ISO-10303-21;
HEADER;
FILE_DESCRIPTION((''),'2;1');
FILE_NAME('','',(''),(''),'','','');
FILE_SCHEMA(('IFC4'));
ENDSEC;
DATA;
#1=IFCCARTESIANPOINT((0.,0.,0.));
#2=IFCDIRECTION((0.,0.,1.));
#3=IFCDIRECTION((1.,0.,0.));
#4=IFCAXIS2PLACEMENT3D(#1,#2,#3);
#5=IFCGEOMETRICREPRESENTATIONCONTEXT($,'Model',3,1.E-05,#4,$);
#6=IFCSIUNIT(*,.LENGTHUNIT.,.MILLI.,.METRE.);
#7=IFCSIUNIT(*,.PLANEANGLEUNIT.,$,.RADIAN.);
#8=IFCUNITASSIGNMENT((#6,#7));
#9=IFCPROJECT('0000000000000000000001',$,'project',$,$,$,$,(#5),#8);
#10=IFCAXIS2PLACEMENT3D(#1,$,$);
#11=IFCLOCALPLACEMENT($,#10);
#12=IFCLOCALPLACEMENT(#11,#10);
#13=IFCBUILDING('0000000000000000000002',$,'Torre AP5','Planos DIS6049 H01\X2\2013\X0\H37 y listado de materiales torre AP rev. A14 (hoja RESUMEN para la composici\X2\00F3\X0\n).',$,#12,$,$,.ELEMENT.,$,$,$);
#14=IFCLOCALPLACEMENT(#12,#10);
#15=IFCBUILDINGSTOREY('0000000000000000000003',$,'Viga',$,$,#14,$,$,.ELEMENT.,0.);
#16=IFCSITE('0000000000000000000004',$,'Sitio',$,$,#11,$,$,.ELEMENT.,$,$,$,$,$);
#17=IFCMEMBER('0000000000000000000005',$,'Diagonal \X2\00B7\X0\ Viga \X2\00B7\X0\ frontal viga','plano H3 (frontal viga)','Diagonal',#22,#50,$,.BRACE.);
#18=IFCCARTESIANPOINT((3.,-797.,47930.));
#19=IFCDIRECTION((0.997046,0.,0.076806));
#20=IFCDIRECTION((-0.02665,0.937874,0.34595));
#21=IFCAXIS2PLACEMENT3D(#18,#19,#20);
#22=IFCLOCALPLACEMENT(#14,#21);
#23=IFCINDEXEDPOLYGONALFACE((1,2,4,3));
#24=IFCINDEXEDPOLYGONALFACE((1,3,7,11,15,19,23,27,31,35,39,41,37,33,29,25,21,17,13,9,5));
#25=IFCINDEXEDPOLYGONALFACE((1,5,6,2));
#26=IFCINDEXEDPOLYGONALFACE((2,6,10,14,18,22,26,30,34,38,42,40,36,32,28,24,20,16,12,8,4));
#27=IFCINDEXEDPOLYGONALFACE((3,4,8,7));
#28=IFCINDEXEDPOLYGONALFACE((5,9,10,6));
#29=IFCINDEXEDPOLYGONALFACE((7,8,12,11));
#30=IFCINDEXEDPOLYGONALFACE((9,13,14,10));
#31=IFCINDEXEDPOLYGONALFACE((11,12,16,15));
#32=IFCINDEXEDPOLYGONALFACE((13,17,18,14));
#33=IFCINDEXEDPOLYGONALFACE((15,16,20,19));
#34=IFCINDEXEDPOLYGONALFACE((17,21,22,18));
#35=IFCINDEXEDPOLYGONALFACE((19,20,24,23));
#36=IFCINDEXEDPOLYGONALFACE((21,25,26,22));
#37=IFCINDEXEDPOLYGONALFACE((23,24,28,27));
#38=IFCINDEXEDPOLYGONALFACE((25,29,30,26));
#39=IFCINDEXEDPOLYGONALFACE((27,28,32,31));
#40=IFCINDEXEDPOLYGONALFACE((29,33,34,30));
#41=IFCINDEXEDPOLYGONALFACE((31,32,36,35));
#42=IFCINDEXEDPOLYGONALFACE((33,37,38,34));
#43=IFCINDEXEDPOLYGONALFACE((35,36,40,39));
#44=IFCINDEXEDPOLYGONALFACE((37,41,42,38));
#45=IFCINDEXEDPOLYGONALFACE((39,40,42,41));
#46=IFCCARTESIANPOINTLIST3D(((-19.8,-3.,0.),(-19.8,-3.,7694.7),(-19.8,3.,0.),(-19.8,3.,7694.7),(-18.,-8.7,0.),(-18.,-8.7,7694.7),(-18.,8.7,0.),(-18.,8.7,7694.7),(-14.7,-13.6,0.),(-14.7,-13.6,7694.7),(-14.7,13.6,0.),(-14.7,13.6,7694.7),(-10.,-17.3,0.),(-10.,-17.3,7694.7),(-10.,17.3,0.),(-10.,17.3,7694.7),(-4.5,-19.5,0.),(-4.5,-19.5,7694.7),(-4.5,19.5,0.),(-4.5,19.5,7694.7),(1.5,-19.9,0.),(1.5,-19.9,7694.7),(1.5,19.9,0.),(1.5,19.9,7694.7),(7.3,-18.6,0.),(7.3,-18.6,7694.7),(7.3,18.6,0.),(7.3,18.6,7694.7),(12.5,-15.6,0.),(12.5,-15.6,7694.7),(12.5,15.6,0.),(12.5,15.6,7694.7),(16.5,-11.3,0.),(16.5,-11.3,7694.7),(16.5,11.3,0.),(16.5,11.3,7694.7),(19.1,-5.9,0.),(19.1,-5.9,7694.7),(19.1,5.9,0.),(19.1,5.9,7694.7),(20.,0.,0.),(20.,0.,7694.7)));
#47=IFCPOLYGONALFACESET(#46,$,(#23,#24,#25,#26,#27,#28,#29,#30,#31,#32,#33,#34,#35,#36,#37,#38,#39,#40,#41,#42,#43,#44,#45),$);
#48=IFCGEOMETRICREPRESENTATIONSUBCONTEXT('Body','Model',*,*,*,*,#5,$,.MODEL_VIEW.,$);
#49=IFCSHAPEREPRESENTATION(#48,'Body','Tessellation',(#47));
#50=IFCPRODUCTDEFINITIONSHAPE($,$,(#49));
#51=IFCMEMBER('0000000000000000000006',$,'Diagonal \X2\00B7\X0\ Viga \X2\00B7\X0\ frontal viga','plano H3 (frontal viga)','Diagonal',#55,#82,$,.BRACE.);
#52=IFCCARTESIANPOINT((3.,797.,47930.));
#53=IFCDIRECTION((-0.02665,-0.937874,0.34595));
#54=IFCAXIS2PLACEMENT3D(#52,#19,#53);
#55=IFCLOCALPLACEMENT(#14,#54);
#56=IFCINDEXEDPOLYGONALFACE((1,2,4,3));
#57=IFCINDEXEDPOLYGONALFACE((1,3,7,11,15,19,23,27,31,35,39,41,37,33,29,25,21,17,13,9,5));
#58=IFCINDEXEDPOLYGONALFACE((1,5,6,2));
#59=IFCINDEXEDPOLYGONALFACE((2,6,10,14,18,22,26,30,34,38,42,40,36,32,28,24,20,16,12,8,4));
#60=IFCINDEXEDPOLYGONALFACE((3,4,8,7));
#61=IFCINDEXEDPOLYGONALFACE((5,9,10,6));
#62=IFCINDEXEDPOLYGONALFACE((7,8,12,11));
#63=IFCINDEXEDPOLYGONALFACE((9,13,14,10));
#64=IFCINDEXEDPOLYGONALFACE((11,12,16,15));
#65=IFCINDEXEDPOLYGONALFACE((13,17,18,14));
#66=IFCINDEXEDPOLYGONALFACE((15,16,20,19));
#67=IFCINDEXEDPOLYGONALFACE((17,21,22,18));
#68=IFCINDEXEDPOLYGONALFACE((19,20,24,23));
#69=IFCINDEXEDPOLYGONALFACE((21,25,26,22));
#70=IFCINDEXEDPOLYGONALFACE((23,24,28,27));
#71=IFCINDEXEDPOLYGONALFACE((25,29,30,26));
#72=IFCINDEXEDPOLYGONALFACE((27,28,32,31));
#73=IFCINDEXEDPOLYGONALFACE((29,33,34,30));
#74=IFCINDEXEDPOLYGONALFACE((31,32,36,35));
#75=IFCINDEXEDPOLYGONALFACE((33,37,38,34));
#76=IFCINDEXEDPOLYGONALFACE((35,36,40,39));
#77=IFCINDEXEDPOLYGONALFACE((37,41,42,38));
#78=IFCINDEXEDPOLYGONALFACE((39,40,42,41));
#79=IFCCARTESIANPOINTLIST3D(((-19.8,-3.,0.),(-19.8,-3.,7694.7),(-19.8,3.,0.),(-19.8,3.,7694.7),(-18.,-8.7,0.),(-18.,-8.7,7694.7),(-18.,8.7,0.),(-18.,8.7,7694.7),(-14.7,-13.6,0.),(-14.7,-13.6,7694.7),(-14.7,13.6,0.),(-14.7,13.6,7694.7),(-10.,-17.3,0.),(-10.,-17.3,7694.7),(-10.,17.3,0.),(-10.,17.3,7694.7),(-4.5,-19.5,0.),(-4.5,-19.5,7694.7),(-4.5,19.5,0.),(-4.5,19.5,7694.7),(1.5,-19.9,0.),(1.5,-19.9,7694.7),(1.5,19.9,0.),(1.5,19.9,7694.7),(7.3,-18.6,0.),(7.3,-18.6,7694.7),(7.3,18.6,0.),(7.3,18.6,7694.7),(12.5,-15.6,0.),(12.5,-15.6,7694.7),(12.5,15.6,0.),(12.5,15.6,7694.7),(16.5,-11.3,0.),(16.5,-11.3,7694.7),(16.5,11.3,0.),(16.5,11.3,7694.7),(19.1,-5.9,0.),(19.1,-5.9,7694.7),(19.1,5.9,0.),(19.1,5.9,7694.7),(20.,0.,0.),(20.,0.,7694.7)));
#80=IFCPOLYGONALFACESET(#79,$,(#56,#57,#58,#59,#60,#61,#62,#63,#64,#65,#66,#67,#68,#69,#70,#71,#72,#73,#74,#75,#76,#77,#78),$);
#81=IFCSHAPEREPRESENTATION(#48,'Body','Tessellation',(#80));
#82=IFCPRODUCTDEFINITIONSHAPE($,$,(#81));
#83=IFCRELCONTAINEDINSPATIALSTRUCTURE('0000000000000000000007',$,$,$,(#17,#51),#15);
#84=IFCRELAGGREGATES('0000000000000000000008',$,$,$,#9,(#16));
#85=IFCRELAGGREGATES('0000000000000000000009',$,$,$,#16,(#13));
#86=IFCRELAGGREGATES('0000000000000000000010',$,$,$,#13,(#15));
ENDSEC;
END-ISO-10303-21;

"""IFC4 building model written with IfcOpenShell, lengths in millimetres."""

from ifc_helpers import new_model, si_unit, frame, origin, origin_with_axes, place, context, subcontext, project, spatial, circle, extrude, element, save


model = new_model("IFC4")

# Units and contexts
model_context = context("Model", 3, precision=1e-05, world=origin_with_axes())
body_context = subcontext(model_context, "Body", "Model", "MODEL_VIEW")
ifc_project = project(units=[si_unit("LENGTHUNIT", "METRE", prefix="MILLI"), si_unit("PLANEANGLEUNIT", "RADIAN")], contexts=[model_context])

# Site, building, storey
site_placement = place(None, origin())
site = spatial("IfcSite", under=ifc_project, at=site_placement, Name="Sitio", CompositionType="ELEMENT")
building_placement = place(site_placement, origin())
building = spatial("IfcBuilding", under=site, at=building_placement, Name="Torre AP5", Description="Planos DIS6049 H01–H37 y listado de materiales torre AP rev. A14 (hoja RESUMEN para la composición).", CompositionType="ELEMENT")
storey_placement = place(building_placement, origin())
storey = spatial("IfcBuildingStorey", under=building, at=storey_placement, Name="Viga", CompositionType="ELEMENT", Elevation=0.0)

# Members
for number, where, z_axis, x_axis, name in (
    (1, (3.0, -797.0, 47930.0), (0.997046, 0.0, 0.076806), (-0.02665, 0.937874, 0.34595), "Diagonal · Viga · frontal viga"),
    (2, (3.0, 797.0, 47930.0), (0.997046, 0.0, 0.076806), (-0.02665, -0.937874, 0.34595), "Diagonal · Viga · frontal viga"),
):
    element("IfcMember", number, at=place(storey_placement, frame(where, z_axis=z_axis, x_axis=x_axis)), inside=storey, Name=name, Description="plano H3 (frontal viga)", ObjectType="Diagonal", PredefinedType="BRACE", context=body_context, shape_type="SweptSolid", body=[
        extrude(circle(Radius=20.0), None, (0.0, 0.0, 1.0), 7694.7),
    ])

save(model, "model.ifc")
